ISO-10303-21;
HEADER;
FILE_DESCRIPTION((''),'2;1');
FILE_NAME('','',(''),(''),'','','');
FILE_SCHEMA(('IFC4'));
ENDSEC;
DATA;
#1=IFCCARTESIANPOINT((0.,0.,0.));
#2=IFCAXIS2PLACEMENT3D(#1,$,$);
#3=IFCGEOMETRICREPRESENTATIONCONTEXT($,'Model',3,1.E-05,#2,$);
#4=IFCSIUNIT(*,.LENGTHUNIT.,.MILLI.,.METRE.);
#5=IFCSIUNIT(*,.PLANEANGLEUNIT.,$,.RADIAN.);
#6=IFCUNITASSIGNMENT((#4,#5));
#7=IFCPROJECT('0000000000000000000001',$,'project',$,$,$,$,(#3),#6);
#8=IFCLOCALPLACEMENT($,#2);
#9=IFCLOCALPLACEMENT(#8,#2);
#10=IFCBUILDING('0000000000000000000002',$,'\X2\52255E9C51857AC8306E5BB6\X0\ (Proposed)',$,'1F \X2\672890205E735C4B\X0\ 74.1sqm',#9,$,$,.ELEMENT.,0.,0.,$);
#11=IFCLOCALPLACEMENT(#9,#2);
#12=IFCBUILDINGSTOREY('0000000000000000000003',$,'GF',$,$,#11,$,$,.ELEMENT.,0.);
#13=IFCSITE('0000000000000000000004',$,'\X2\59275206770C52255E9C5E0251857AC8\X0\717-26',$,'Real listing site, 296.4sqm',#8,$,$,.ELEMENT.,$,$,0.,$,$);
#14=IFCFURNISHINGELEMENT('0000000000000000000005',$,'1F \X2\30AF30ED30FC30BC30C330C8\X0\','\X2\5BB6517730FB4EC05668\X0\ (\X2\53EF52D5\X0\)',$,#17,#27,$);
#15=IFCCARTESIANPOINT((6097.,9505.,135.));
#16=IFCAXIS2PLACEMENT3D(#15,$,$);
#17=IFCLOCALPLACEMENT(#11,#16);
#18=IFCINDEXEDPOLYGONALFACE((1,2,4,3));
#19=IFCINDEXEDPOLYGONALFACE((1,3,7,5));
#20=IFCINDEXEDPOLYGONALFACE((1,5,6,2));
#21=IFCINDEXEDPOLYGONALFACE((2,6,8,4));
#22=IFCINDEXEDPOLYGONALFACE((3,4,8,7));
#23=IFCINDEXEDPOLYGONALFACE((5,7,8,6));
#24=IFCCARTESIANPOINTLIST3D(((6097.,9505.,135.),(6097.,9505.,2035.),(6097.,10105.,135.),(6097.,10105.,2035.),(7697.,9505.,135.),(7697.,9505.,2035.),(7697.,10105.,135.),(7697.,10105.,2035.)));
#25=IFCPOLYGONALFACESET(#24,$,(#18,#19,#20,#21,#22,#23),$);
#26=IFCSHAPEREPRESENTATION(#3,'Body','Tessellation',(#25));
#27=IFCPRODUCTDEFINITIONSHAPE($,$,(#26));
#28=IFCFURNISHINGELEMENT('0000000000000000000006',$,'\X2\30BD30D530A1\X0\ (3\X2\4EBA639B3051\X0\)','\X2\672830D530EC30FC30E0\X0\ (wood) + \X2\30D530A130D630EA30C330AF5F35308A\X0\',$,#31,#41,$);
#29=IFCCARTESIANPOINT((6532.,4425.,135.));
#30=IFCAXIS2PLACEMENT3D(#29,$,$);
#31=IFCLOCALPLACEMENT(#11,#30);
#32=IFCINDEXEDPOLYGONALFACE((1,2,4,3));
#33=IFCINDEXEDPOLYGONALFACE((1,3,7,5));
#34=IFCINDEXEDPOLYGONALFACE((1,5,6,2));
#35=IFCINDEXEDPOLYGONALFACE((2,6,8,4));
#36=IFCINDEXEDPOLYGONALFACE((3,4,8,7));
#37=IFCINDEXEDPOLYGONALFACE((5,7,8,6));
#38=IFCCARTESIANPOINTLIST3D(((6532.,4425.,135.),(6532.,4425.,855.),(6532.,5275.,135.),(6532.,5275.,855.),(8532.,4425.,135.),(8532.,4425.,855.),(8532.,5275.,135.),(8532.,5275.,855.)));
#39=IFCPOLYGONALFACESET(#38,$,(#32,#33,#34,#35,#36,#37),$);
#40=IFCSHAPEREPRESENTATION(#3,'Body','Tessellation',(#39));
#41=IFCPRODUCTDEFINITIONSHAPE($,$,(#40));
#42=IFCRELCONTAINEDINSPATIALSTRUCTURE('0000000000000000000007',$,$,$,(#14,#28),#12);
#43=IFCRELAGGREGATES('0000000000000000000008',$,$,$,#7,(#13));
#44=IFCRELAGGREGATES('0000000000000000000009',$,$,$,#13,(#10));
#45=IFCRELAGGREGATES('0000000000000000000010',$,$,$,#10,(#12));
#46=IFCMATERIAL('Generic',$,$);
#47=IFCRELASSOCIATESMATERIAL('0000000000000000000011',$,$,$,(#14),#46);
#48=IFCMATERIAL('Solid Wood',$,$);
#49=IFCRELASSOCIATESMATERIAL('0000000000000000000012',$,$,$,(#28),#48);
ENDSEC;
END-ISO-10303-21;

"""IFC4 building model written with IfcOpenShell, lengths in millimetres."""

from ifc_helpers import new_model, si_unit, frame, frame_2d, origin, place, context, project, spatial, rectangle, extrude, material, element, save


model = new_model("IFC4")

# Units and contexts
model_context = context("Model", 3, precision=1e-05, world=origin())
ifc_project = project(units=[si_unit("LENGTHUNIT", "METRE", prefix="MILLI"), si_unit("PLANEANGLEUNIT", "RADIAN")], contexts=[model_context])

# Site, building, storey
site_placement = place(None, origin())
site = spatial("IfcSite", under=ifc_project, at=site_placement, Name="大分県別府市内竈717-26", ObjectType="Real listing site, 296.4sqm", CompositionType="ELEMENT", RefElevation=0.0)
building_placement = place(site_placement, origin())
building = spatial("IfcBuilding", under=site, at=building_placement, Name="別府内竈の家 (Proposed)", ObjectType="1F 木造平屋 74.1sqm", CompositionType="ELEMENT", ElevationOfRefHeight=0.0, ElevationOfTerrain=0.0)
storey_placement = place(building_placement, origin())
storey = spatial("IfcBuildingStorey", under=building, at=storey_placement, Name="GF", CompositionType="ELEMENT", Elevation=0.0)

# Shared definitions
ifc_material_1 = material(Name="Solid Wood")

# Shared definitions
ifc_material_2 = material(Name="Generic")

# Furnishing elements
furnishing_1_placement = place(storey_placement, frame((6097.0, 9505.0, 135.0)))
element("IfcFurnishingElement", 1, at=furnishing_1_placement, inside=storey, material=ifc_material_2, Name="1F クローゼット", Description="家具・什器 (可動)", context=model_context, shape_type="SweptSolid", body=[
    extrude(rectangle(XDim=1600.0, YDim=600.0, at=frame_2d((800.0, 300.0))), frame((6097.0, 9505.0, 135.0)), (0.0, 0.0, 1.0), 1900.0),
])
furnishing_2_placement = place(storey_placement, frame((6532.0, 4425.0, 135.0)))
element("IfcFurnishingElement", 2, at=furnishing_2_placement, inside=storey, material=ifc_material_1, Name="ソファ (3人掛け)", Description="木フレーム (wood) + ファブリック張り", context=model_context, shape_type="SweptSolid", body=[
    extrude(rectangle(XDim=2000.0, YDim=850.0, at=frame_2d((1000.0, 425.0))), frame((6532.0, 4425.0, 135.0)), (0.0, 0.0, 1.0), 720.0),
])

save(model, "model.ifc")
